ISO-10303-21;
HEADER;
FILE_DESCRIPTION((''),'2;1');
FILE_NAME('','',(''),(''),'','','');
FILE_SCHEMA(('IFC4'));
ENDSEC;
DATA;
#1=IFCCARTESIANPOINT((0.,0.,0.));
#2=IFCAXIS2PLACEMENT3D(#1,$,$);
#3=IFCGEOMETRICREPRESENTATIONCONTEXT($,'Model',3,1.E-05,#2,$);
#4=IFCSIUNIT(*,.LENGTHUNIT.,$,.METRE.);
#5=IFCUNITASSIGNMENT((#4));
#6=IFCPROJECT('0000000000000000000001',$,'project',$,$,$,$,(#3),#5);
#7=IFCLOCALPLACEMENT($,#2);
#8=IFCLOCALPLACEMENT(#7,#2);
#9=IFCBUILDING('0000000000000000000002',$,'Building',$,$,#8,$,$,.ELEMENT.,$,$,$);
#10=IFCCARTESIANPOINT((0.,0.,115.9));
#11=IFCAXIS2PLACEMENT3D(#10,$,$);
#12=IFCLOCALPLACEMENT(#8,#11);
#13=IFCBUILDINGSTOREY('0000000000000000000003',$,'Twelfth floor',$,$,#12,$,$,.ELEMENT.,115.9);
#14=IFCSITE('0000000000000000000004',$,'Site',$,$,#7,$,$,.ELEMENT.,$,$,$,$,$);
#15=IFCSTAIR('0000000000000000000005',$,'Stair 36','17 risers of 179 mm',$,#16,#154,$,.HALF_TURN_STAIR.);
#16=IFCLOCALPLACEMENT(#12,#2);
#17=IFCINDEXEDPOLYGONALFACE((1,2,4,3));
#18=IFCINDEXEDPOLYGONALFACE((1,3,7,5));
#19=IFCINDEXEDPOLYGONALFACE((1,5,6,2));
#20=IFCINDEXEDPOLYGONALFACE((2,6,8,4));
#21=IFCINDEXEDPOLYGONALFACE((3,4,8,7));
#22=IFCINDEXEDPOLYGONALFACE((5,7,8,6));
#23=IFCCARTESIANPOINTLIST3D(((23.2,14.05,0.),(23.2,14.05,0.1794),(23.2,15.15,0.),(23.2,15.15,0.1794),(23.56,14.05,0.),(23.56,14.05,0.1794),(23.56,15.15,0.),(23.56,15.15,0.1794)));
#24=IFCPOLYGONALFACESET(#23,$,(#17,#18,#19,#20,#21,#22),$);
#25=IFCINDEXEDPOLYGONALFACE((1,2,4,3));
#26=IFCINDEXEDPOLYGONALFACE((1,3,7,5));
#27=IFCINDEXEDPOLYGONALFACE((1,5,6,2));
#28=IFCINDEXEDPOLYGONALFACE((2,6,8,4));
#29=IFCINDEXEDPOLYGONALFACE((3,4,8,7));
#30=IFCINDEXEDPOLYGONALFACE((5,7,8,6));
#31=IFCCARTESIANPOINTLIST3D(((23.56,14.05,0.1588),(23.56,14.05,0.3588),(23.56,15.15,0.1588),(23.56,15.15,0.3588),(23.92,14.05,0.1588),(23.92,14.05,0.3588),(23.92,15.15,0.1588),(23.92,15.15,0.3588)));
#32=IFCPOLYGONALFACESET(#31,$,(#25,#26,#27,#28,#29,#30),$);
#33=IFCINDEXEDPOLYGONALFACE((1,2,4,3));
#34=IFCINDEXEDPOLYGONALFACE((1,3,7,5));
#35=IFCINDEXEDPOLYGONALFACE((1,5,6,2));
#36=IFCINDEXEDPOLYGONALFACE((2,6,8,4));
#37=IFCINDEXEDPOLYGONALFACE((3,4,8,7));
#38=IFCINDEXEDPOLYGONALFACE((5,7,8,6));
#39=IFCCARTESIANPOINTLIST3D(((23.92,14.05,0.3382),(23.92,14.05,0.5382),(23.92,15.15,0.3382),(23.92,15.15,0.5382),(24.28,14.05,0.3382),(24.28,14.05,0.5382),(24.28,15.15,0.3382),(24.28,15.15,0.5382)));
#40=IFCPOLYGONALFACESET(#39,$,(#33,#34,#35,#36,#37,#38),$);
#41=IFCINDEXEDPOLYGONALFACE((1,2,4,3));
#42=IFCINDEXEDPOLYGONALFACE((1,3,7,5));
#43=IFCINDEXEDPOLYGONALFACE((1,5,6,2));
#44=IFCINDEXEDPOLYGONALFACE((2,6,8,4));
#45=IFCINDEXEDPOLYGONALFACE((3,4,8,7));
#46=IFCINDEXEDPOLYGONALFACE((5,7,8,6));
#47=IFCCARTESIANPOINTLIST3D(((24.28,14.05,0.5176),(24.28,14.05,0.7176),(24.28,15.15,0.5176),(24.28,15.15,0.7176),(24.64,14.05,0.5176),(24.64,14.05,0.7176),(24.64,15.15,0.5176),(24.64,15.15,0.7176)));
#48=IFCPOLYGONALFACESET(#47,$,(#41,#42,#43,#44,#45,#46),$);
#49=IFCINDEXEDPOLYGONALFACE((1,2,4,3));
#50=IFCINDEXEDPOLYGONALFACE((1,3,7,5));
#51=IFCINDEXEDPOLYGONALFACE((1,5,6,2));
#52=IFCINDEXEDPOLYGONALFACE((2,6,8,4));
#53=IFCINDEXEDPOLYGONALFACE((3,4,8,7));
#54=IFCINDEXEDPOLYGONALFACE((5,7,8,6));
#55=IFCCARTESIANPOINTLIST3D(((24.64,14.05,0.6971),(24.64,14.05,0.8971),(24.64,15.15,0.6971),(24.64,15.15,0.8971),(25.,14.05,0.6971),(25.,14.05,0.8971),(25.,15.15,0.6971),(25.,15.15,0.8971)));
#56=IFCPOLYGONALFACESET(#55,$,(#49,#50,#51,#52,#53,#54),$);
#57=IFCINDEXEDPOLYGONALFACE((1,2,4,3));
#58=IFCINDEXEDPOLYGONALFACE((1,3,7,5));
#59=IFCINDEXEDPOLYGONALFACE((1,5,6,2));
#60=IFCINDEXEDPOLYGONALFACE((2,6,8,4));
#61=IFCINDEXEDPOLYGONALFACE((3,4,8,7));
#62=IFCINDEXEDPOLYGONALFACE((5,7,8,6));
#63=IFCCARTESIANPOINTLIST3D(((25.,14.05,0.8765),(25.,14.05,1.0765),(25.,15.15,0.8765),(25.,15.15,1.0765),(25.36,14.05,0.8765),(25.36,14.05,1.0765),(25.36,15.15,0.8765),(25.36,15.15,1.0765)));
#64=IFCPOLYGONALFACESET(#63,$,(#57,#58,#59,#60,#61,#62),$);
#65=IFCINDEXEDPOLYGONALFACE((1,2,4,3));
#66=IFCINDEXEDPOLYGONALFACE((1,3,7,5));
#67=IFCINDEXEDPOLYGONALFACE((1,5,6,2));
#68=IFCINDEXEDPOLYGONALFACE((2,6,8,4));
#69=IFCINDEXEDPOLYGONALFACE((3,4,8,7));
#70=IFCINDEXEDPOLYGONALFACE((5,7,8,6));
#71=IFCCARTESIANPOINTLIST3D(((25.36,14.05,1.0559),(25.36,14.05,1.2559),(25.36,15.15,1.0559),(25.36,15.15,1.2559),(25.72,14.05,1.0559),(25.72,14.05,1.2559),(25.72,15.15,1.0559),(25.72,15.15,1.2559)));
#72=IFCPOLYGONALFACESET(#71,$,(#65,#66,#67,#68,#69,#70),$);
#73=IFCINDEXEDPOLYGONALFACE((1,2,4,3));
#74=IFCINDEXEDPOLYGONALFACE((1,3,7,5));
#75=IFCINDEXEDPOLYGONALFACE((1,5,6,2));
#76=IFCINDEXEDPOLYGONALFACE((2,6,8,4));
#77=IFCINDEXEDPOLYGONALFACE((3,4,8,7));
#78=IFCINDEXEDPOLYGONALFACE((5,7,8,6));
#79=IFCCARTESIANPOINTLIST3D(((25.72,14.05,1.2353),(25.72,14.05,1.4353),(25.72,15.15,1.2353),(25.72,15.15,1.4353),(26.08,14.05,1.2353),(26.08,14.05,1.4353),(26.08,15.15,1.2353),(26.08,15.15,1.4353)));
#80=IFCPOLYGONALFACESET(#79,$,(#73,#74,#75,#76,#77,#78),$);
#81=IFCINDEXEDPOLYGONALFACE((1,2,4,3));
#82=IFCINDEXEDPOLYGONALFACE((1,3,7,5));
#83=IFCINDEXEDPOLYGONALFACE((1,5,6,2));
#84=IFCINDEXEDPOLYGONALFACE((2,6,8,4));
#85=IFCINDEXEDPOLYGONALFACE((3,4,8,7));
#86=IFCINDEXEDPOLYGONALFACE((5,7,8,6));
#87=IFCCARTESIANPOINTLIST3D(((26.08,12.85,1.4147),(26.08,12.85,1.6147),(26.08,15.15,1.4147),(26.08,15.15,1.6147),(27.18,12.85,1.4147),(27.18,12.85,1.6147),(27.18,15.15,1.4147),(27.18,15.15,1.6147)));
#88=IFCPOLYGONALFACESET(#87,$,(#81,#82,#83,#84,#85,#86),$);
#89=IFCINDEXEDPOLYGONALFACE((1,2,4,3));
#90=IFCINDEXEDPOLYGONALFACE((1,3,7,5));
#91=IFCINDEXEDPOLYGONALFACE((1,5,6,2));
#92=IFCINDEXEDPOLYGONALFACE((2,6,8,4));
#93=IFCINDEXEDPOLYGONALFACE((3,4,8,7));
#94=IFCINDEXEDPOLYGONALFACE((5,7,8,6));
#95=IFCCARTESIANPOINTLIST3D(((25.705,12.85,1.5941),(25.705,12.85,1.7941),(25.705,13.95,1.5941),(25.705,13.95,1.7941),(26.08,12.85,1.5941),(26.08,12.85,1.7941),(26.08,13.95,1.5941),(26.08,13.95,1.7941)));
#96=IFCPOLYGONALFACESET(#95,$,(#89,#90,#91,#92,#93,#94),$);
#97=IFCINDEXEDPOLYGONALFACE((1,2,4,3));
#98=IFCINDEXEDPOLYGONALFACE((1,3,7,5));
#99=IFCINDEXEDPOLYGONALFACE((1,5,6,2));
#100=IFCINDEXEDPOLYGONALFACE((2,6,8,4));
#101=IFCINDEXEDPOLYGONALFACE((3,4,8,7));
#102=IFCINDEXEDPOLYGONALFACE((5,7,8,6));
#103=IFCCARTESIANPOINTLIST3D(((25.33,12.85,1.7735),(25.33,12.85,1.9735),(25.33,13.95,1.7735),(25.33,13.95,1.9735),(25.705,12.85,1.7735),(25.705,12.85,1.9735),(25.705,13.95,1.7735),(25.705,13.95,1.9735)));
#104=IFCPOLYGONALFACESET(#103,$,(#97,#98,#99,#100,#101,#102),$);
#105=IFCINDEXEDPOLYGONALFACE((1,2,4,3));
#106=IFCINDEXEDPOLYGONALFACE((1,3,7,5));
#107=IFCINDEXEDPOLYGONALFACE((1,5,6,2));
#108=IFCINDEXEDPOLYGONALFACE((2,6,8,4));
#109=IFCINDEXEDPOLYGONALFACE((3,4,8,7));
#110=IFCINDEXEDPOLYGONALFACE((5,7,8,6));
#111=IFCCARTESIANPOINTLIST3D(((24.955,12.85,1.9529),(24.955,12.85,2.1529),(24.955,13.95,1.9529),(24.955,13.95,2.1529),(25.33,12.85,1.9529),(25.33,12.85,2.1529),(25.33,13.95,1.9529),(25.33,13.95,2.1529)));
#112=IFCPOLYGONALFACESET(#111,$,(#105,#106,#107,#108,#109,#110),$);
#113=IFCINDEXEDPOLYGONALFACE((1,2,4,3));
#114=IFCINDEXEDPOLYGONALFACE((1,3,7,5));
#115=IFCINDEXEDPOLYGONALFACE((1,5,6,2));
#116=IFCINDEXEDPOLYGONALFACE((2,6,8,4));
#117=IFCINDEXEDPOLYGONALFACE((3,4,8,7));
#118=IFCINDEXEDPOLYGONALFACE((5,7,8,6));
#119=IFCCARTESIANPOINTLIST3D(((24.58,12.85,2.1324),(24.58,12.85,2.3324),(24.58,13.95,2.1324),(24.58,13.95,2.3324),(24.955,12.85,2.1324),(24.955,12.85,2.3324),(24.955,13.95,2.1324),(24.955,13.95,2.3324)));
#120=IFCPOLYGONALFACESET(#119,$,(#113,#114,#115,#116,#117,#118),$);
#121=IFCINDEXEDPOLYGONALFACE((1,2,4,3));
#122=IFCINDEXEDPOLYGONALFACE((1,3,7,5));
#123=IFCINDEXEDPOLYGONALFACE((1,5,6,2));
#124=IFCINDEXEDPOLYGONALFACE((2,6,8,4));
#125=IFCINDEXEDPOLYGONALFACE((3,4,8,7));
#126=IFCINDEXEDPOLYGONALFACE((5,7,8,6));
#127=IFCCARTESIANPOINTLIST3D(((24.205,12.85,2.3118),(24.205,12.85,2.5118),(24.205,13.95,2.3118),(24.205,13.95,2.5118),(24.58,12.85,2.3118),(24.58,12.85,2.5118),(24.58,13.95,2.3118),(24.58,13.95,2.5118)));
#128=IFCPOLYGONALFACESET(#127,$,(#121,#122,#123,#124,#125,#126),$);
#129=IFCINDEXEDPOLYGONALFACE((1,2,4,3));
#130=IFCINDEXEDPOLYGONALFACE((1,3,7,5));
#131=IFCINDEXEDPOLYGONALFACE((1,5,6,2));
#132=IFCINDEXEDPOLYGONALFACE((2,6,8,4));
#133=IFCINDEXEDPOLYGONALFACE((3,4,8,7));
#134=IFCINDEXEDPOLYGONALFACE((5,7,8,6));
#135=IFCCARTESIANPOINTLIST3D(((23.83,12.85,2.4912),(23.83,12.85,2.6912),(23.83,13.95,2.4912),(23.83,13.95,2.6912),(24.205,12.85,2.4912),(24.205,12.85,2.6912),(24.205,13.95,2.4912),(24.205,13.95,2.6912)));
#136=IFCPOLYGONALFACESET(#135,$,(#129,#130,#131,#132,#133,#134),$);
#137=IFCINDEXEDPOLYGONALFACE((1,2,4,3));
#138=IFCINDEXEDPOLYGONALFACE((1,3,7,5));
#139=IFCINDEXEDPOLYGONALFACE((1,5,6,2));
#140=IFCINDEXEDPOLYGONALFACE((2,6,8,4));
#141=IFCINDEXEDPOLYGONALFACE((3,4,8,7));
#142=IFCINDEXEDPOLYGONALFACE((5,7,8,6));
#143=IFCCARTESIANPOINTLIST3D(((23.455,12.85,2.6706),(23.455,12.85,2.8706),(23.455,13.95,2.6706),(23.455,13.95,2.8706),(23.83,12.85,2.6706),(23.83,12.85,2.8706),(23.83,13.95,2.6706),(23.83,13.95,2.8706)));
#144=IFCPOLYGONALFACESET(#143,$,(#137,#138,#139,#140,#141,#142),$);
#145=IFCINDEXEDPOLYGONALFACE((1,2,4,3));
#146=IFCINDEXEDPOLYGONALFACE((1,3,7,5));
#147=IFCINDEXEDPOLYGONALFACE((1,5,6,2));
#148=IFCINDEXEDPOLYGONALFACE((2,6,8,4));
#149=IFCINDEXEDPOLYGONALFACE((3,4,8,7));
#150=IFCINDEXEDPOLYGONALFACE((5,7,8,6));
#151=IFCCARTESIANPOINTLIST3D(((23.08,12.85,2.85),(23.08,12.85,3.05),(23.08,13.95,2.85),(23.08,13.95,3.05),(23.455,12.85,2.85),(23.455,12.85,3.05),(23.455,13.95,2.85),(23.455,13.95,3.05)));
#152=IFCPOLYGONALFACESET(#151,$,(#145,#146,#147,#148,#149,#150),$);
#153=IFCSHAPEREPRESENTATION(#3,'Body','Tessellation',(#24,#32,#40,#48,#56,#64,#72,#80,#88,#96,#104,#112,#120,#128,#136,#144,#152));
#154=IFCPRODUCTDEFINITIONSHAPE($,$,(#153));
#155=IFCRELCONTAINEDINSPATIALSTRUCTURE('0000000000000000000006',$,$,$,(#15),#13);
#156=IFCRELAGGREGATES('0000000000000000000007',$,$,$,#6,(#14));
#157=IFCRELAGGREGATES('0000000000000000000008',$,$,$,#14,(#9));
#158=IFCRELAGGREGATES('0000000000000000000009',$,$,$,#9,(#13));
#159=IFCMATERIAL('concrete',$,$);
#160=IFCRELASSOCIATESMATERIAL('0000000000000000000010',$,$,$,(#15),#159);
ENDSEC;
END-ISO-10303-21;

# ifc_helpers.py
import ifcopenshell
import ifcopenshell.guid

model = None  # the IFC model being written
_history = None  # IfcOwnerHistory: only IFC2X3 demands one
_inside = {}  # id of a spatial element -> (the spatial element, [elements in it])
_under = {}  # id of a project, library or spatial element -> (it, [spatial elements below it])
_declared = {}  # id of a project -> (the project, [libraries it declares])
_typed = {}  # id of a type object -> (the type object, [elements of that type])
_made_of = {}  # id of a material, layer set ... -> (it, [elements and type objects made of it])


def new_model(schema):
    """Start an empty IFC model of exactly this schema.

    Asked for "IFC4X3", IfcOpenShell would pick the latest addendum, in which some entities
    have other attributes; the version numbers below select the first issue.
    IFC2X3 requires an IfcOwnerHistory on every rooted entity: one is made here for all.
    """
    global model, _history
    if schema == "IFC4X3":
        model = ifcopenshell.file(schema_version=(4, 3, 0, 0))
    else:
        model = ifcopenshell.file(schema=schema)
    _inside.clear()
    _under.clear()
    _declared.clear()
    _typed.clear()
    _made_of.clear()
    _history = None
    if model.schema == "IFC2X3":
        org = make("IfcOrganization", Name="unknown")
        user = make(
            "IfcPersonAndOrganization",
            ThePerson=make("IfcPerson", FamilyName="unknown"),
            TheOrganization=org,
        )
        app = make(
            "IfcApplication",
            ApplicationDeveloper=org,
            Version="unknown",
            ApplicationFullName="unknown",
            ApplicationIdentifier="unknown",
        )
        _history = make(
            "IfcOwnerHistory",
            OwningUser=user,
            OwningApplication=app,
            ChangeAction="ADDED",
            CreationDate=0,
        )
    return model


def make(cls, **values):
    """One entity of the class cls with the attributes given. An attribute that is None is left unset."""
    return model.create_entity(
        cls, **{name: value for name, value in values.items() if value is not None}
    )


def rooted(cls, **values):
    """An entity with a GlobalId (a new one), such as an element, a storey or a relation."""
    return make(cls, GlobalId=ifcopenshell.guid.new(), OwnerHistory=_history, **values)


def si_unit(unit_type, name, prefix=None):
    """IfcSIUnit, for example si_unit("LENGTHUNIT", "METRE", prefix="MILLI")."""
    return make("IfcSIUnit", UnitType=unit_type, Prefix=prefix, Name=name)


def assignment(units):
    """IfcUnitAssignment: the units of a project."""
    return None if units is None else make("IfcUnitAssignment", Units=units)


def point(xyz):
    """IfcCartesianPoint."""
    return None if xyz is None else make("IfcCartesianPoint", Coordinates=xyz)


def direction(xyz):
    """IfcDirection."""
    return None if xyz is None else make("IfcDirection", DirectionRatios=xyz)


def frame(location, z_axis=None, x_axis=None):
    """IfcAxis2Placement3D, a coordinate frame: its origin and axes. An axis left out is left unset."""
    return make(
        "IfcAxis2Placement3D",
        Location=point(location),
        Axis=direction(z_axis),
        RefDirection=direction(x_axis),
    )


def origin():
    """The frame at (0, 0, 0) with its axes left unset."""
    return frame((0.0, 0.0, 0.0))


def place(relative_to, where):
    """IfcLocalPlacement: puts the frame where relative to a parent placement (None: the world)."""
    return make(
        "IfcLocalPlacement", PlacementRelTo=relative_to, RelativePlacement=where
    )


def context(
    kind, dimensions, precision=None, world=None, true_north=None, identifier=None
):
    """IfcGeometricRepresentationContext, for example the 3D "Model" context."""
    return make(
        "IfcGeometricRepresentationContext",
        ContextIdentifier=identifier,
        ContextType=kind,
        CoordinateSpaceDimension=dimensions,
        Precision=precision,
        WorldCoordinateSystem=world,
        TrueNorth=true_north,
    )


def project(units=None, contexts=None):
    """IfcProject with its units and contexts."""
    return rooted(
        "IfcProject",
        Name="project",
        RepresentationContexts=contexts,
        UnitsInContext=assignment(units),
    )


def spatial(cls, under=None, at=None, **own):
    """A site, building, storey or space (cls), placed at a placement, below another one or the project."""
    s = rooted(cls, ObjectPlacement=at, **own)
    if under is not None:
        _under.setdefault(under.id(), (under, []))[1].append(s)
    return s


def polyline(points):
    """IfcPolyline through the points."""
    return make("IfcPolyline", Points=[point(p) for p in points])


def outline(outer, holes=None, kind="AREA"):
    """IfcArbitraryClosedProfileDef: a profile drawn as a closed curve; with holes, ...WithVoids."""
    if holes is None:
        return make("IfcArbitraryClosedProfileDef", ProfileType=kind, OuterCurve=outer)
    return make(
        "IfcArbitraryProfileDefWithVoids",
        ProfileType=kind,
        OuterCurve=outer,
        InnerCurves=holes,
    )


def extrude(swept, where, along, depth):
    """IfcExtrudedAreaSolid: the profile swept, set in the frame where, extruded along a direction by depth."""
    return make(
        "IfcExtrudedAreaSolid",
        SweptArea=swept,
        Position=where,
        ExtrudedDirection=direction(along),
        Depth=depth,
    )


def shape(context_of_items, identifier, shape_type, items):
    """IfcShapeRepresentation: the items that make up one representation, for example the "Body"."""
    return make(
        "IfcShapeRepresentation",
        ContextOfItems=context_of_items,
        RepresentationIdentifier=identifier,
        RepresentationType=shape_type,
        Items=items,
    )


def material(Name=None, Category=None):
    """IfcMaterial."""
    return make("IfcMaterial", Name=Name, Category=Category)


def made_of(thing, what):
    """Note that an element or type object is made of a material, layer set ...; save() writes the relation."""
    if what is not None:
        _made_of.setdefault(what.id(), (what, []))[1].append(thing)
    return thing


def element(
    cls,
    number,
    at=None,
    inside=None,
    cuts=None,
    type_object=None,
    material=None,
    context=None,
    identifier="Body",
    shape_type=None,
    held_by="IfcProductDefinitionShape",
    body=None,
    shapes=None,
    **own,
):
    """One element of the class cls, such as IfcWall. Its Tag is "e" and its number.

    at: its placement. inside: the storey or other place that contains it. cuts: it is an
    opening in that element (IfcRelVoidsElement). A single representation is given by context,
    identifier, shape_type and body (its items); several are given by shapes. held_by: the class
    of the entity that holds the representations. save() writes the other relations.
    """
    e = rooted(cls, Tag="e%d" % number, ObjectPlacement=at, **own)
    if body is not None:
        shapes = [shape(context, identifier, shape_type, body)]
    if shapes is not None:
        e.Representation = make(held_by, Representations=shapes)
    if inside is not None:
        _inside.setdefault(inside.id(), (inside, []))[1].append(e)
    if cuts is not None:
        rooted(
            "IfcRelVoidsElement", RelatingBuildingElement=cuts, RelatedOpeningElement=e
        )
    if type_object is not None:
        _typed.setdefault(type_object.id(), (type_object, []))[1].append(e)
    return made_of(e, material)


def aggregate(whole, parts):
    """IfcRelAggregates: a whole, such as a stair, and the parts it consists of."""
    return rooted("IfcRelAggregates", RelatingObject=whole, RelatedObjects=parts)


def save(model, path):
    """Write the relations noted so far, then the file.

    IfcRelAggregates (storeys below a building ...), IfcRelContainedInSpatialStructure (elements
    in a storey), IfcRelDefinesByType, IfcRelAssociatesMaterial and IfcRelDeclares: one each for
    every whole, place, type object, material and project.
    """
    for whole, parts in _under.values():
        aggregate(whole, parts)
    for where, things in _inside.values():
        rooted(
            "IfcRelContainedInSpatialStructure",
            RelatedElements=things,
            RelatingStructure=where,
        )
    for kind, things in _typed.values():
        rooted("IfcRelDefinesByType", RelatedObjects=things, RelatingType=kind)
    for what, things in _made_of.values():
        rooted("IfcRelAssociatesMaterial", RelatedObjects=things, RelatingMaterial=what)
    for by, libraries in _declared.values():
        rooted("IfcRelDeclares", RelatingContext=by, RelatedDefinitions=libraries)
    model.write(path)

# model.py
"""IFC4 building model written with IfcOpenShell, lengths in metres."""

from ifc_helpers import new_model, si_unit, frame, origin, place, context, project, spatial, polyline, outline, extrude, material, element, save


model = new_model("IFC4")

# Units and contexts
model_context = context("Model", 3, precision=1e-05, world=origin())
ifc_project = project(units=[si_unit("LENGTHUNIT", "METRE")], contexts=[model_context])

# Site, building, storey
site_placement = place(None, origin())
site = spatial("IfcSite", under=ifc_project, at=site_placement, Name="Site", CompositionType="ELEMENT")
building_placement = place(site_placement, origin())
building = spatial("IfcBuilding", under=site, at=building_placement, Name="Building", CompositionType="ELEMENT")
storey_placement = place(building_placement, frame((0.0, 0.0, 115.9)))
storey = spatial("IfcBuildingStorey", under=building, at=storey_placement, Name="Twelfth floor", CompositionType="ELEMENT", Elevation=115.9)

# Shared definitions
ifc_material = material(Name="concrete")

# Stair
stair_placement = place(storey_placement, frame((23.2, 14.6, 0.0), z_axis=(0.0, 0.0, 1.0), x_axis=(1.0, 0.0, 0.0)))
element("IfcStair", 1, at=stair_placement, inside=storey, material=ifc_material, Name="Stair 36", Description="17 risers of 179 mm", PredefinedType="HALF_TURN_STAIR", context=model_context, shape_type="SweptSolid", body=[
    extrude(outline(polyline([(0.0, -0.55), (0.36, -0.55), (0.36, 0.55), (0.0, 0.55), (0.0, -0.55)])), origin(), (0.0, 0.0, 1.0), 0.1794),
    extrude(outline(polyline([(0.36, -0.55), (0.72, -0.55), (0.72, 0.55), (0.36, 0.55), (0.36, -0.55)])), frame((0.0, 0.0, 0.1588)), (0.0, 0.0, 1.0), 0.2),
    extrude(outline(polyline([(0.72, -0.55), (1.08, -0.55), (1.08, 0.55), (0.72, 0.55), (0.72, -0.55)])), frame((0.0, 0.0, 0.3382)), (0.0, 0.0, 1.0), 0.2),
    extrude(outline(polyline([(1.08, -0.55), (1.44, -0.55), (1.44, 0.55), (1.08, 0.55), (1.08, -0.55)])), frame((0.0, 0.0, 0.5176)), (0.0, 0.0, 1.0), 0.2),
    extrude(outline(polyline([(1.44, -0.55), (1.8, -0.55), (1.8, 0.55), (1.44, 0.55), (1.44, -0.55)])), frame((0.0, 0.0, 0.6971)), (0.0, 0.0, 1.0), 0.2),
    extrude(outline(polyline([(1.8, -0.55), (2.16, -0.55), (2.16, 0.55), (1.8, 0.55), (1.8, -0.55)])), frame((0.0, 0.0, 0.8765)), (0.0, 0.0, 1.0), 0.2),
    extrude(outline(polyline([(2.16, -0.55), (2.52, -0.55), (2.52, 0.55), (2.16, 0.55), (2.16, -0.55)])), frame((0.0, 0.0, 1.0559)), (0.0, 0.0, 1.0), 0.2),
    extrude(outline(polyline([(2.52, -0.55), (2.88, -0.55), (2.88, 0.55), (2.52, 0.55), (2.52, -0.55)])), frame((0.0, 0.0, 1.2353)), (0.0, 0.0, 1.0), 0.2),
    extrude(outline(polyline([(2.88, -1.75), (3.98, -1.75), (3.98, 0.55), (2.88, 0.55), (2.88, -1.75)])), frame((0.0, 0.0, 1.4147)), (0.0, 0.0, 1.0), 0.2),
    extrude(outline(polyline([(2.505, -1.75), (2.88, -1.75), (2.88, -0.65), (2.505, -0.65), (2.505, -1.75)])), frame((0.0, 0.0, 1.5941)), (0.0, 0.0, 1.0), 0.2),
    extrude(outline(polyline([(2.13, -1.75), (2.505, -1.75), (2.505, -0.65), (2.13, -0.65), (2.13, -1.75)])), frame((0.0, 0.0, 1.7735)), (0.0, 0.0, 1.0), 0.2),
    extrude(outline(polyline([(1.755, -1.75), (2.13, -1.75), (2.13, -0.65), (1.755, -0.65), (1.755, -1.75)])), frame((0.0, 0.0, 1.9529)), (0.0, 0.0, 1.0), 0.2),
    extrude(outline(polyline([(1.38, -1.75), (1.755, -1.75), (1.755, -0.65), (1.38, -0.65), (1.38, -1.75)])), frame((0.0, 0.0, 2.1324)), (0.0, 0.0, 1.0), 0.2),
    extrude(outline(polyline([(1.005, -1.75), (1.38, -1.75), (1.38, -0.65), (1.005, -0.65), (1.005, -1.75)])), frame((0.0, 0.0, 2.3118)), (0.0, 0.0, 1.0), 0.2),
    extrude(outline(polyline([(0.63, -1.75), (1.005, -1.75), (1.005, -0.65), (0.63, -0.65), (0.63, -1.75)])), frame((0.0, 0.0, 2.4912)), (0.0, 0.0, 1.0), 0.2),
    extrude(outline(polyline([(0.255, -1.75), (0.63, -1.75), (0.63, -0.65), (0.255, -0.65), (0.255, -1.75)])), frame((0.0, 0.0, 2.6706)), (0.0, 0.0, 1.0), 0.2),
    extrude(outline(polyline([(-0.12, -1.75), (0.255, -1.75), (0.255, -0.65), (-0.12, -0.65), (-0.12, -1.75)])), frame((0.0, 0.0, 2.85)), (0.0, 0.0, 1.0), 0.2),
])

save(model, "model.ifc")
